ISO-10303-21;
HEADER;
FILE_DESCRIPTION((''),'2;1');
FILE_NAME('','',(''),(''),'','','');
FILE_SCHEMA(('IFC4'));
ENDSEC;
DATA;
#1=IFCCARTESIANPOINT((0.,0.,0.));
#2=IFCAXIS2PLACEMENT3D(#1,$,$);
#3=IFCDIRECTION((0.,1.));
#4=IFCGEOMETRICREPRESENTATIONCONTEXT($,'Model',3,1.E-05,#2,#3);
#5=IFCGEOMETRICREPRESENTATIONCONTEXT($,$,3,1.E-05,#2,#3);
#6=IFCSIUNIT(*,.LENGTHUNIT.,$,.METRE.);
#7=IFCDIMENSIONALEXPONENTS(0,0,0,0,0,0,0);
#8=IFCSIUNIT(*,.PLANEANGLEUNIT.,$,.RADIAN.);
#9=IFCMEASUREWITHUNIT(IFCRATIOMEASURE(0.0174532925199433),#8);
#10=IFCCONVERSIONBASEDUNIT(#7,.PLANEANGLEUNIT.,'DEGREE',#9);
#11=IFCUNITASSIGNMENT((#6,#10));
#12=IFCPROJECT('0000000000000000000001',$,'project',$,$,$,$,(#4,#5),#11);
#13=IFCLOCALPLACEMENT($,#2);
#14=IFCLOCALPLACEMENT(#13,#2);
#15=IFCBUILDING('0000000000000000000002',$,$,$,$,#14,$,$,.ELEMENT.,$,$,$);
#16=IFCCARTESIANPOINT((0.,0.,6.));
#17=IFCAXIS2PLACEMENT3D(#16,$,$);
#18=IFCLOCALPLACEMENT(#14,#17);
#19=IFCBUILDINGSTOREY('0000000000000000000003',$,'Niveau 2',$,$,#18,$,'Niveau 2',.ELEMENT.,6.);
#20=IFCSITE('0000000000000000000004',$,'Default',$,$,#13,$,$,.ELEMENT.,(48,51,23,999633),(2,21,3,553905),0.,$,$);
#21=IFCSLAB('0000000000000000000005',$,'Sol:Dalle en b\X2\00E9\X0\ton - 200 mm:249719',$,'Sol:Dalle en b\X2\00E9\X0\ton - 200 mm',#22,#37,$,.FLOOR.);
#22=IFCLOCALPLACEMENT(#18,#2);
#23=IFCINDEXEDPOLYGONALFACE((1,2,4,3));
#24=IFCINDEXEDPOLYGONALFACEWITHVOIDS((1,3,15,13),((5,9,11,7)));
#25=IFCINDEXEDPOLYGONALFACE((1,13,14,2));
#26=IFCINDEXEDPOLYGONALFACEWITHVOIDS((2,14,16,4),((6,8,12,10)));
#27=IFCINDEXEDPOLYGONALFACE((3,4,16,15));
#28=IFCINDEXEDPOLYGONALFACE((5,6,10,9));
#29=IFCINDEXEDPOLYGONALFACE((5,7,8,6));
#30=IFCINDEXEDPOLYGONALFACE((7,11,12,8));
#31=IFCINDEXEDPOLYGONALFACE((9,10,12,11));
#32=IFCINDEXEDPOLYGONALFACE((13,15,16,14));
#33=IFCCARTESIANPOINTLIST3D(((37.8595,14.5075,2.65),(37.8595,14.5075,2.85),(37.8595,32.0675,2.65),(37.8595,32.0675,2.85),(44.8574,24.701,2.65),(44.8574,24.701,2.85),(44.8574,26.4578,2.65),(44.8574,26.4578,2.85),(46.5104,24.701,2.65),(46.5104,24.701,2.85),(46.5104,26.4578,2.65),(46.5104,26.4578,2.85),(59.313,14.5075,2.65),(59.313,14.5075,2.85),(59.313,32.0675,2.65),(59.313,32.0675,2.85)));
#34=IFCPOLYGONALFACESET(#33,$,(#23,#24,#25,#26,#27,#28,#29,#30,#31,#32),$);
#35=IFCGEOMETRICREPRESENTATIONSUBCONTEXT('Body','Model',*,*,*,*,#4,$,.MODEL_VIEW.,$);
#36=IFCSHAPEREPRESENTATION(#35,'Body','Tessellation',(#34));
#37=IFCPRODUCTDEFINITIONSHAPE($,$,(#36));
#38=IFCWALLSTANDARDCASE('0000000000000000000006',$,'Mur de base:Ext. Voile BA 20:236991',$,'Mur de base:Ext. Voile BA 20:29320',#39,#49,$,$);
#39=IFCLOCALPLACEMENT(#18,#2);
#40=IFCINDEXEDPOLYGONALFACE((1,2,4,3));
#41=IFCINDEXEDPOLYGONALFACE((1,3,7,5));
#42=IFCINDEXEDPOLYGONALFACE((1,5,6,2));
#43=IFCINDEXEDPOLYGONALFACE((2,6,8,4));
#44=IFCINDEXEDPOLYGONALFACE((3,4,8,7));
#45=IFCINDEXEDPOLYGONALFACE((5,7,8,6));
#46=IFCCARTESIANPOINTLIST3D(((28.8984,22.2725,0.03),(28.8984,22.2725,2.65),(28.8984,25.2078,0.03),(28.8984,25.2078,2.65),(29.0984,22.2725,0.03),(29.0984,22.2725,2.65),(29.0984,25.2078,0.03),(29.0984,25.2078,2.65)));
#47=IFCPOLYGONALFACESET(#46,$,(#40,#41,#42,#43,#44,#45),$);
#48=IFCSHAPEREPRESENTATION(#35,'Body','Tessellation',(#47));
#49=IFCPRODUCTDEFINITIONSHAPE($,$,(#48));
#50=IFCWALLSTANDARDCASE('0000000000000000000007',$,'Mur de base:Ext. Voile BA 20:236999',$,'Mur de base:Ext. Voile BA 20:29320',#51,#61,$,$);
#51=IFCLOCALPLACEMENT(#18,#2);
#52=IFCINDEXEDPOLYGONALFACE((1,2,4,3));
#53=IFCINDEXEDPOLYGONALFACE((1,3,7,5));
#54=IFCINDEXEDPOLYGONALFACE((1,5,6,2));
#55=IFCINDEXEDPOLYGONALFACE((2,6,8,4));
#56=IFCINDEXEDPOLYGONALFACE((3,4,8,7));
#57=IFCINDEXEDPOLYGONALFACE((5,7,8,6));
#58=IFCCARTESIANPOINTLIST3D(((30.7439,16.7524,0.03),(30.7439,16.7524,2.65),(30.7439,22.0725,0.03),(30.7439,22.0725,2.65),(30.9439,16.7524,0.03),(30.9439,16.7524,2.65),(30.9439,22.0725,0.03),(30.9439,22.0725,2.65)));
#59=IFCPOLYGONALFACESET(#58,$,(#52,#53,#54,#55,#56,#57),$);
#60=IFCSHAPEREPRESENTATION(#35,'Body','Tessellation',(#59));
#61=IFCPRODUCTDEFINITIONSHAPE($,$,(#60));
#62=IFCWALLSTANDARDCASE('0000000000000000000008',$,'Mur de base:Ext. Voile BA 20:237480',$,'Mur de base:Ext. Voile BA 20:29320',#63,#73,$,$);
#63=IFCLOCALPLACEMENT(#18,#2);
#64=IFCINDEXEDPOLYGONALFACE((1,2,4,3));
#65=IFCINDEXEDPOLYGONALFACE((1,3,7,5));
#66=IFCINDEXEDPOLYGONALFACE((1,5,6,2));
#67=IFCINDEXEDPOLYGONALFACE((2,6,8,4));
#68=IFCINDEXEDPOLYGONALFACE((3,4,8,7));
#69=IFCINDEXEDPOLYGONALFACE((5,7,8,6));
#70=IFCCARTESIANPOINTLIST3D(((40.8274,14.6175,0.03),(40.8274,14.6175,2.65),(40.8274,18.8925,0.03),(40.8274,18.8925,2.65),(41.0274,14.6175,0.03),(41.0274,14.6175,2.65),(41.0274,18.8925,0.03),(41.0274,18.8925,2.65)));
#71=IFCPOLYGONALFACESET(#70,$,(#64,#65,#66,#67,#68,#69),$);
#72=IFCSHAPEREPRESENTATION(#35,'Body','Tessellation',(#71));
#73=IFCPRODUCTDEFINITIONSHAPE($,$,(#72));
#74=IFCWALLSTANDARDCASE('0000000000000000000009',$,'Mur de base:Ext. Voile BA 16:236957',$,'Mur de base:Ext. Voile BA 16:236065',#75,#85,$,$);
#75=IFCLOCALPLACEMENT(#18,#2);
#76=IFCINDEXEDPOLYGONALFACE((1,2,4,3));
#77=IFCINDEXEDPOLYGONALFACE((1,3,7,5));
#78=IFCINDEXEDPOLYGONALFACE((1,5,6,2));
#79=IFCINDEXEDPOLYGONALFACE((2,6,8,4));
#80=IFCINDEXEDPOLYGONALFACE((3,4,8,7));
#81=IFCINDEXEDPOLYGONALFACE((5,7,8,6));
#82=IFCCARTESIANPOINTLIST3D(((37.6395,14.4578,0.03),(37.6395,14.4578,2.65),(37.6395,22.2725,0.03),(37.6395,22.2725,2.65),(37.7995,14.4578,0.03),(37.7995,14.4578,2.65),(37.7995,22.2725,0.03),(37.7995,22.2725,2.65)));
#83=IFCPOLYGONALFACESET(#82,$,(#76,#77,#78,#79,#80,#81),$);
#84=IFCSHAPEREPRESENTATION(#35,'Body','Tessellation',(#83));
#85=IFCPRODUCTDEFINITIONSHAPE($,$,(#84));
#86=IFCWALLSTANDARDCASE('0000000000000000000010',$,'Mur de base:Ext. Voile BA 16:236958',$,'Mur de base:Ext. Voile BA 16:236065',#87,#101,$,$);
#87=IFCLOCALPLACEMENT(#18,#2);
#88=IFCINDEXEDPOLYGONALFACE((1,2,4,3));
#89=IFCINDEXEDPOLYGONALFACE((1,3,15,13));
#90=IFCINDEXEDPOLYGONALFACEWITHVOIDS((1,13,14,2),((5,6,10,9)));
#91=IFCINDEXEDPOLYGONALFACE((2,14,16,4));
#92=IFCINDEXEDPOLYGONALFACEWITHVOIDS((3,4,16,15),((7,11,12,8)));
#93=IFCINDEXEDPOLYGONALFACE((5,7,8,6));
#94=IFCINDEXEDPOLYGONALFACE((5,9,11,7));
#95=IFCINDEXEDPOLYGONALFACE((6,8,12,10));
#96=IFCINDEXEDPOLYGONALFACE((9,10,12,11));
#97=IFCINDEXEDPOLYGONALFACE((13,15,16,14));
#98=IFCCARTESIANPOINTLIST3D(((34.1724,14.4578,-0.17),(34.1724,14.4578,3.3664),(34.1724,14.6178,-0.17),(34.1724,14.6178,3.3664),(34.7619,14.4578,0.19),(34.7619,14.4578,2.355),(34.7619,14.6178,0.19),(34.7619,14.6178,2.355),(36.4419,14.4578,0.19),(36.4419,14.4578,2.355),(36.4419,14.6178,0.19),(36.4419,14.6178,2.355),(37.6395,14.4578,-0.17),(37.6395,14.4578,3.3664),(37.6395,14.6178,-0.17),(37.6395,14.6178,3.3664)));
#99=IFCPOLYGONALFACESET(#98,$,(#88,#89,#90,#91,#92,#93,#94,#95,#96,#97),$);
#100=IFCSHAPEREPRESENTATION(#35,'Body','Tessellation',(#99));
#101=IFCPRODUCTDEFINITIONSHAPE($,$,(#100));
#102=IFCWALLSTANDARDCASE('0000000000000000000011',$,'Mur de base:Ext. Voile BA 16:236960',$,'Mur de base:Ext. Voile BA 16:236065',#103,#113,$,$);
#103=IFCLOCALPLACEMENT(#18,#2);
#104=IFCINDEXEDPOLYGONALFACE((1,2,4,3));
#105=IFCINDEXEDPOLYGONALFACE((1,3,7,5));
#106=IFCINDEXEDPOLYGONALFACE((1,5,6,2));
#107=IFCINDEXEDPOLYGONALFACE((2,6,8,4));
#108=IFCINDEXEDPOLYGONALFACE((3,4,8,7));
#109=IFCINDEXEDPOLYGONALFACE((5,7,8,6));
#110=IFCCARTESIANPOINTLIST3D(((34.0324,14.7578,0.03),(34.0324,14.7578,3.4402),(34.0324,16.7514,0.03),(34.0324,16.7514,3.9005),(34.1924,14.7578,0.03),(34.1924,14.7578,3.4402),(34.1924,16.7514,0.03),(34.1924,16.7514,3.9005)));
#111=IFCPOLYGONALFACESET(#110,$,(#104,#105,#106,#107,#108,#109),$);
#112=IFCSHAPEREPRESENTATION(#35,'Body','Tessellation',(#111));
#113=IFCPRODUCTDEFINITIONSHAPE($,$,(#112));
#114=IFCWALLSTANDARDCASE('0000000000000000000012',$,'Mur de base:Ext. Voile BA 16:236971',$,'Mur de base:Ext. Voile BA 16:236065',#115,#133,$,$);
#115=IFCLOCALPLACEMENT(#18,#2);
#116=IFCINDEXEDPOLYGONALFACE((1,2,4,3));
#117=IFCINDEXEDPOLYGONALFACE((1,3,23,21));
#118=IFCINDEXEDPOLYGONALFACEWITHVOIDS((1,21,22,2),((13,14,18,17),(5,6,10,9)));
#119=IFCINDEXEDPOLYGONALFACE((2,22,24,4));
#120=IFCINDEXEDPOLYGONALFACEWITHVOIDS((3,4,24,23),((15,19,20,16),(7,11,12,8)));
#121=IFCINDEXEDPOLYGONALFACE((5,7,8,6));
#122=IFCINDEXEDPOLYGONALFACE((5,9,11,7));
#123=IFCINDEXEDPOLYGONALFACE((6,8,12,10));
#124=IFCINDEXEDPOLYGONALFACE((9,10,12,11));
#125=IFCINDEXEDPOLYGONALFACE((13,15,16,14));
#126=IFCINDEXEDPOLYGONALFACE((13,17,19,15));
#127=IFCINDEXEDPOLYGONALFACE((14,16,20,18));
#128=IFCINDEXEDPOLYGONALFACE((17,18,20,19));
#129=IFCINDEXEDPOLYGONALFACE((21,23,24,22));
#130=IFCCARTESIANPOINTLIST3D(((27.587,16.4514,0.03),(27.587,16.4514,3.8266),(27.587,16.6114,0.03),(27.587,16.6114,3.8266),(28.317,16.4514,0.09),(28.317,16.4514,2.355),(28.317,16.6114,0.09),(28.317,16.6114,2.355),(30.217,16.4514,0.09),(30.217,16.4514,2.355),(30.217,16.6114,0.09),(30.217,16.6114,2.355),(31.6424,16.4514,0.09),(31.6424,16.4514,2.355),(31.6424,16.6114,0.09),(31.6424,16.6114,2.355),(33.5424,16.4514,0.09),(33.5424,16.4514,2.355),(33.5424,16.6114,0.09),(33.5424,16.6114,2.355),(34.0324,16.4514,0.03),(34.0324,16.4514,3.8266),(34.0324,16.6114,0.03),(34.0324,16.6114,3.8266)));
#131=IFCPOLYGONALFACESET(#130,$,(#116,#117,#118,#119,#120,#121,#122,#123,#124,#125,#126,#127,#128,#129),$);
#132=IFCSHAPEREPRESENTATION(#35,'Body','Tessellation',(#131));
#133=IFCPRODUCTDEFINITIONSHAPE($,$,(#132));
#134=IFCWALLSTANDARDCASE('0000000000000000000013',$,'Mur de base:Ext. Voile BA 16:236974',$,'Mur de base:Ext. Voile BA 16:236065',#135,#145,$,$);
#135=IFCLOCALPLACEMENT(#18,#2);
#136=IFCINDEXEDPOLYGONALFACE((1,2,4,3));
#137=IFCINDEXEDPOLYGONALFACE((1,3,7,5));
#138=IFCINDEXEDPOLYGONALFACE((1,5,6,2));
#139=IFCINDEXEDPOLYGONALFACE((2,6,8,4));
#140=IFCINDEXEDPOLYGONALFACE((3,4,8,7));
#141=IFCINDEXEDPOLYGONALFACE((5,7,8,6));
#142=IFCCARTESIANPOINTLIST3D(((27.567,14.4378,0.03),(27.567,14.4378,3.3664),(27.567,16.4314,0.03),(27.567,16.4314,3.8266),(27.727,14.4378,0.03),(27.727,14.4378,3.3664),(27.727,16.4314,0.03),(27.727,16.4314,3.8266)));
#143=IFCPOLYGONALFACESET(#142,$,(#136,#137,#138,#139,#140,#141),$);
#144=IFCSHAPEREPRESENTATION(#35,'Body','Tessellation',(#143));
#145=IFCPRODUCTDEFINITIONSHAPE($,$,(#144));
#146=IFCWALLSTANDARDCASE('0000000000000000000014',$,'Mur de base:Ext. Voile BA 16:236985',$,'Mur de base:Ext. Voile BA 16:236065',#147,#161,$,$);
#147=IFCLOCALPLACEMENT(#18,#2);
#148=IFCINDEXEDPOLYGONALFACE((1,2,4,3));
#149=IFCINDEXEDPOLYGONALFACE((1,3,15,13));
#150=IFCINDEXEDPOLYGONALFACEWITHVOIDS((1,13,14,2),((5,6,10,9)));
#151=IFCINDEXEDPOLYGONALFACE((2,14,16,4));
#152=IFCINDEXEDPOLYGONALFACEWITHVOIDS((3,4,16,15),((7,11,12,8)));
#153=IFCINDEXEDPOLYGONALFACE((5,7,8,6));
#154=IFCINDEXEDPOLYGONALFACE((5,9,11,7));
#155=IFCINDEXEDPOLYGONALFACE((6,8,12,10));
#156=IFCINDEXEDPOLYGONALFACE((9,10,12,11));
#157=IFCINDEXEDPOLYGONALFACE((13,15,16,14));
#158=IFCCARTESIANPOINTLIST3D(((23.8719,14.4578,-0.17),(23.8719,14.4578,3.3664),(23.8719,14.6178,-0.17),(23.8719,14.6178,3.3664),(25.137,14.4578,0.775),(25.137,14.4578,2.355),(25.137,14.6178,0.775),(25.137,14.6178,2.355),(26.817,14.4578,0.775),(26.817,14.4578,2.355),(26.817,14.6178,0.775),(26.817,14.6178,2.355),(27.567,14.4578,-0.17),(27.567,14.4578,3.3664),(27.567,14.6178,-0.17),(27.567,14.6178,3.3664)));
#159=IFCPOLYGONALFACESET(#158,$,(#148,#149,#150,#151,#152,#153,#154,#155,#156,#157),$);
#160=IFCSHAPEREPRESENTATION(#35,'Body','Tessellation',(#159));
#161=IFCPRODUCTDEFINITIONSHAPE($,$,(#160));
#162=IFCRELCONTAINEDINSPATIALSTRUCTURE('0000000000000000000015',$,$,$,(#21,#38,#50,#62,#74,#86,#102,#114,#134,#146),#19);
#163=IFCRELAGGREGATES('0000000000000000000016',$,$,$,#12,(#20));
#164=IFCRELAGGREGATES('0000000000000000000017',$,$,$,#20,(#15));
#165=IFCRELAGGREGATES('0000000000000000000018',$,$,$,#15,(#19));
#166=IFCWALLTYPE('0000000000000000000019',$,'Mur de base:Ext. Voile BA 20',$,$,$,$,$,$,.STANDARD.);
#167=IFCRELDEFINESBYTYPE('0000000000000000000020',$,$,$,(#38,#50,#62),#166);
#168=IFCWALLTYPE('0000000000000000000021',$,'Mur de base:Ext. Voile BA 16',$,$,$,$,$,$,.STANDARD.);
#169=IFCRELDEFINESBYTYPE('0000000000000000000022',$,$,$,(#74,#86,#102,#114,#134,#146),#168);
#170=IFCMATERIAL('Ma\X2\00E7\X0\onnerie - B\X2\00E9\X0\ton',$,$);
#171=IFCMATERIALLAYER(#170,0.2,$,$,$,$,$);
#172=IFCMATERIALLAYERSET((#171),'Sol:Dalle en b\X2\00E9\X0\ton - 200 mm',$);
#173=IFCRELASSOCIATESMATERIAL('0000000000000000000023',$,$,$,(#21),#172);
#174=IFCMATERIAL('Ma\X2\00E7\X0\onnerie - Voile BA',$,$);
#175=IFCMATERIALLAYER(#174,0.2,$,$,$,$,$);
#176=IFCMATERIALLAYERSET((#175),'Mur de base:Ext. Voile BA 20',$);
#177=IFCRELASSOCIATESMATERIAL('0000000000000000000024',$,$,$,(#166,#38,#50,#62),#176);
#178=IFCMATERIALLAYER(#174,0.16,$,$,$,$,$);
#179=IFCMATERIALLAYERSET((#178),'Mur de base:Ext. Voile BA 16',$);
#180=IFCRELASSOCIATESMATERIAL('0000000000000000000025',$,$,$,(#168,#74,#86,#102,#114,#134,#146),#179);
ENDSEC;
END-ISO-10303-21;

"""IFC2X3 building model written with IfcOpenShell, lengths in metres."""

from ifc_helpers import new_model, entity, si_unit, converted_unit, direction, frame, frame_2d, origin, origin_2d_with_axis, place, context, subcontext, project, spatial, rectangle, extrude, clip, halfspace, material, layer, layer_set, layer_usage, type_object, element, save


model = new_model("IFC2X3")

# Units and contexts
model_context = context("Model", 3, precision=1e-05, world=origin(), true_north=direction((0.0, 1.0)))
context_of_model = context(None, 3, precision=1e-05, world=origin(), true_north=direction((0.0, 1.0)))
body_context = subcontext(model_context, "Body", "Model", "MODEL_VIEW")
ifc_project = project(units=[si_unit("LENGTHUNIT", "METRE"), converted_unit("PLANEANGLEUNIT", "DEGREE", entity("IfcRatioMeasure", 0.0174532925199433), si_unit("PLANEANGLEUNIT", "RADIAN"), dimensions=[0, 0, 0, 0, 0, 0, 0])], contexts=[model_context, context_of_model])

# Site, building, storey
site_placement = place(None, origin())
site = spatial("IfcSite", under=ifc_project, at=site_placement, Name="Default", CompositionType="ELEMENT", RefLatitude=(48, 51, 23, 999633), RefLongitude=(2, 21, 3, 553905), RefElevation=0.0)
building_placement = place(site_placement, origin())
building = spatial("IfcBuilding", under=site, at=building_placement, CompositionType="ELEMENT")
storey_placement = place(building_placement, frame((0.0, 0.0, 6.0)))
storey = spatial("IfcBuildingStorey", under=building, at=storey_placement, Name="Niveau 2", LongName="Niveau 2", CompositionType="ELEMENT", Elevation=6.0)

# Slab, opening
ifc_material_1 = material(Name="Maçonnerie - Béton")
ifc_layer_1 = layer(ifc_material_1, 0.2)
ifc_layer_set_1 = layer_set([ifc_layer_1], Name="Sol:Dalle en béton - 200 mm")
ifc_layer_usage_1 = layer_usage(ifc_layer_set_1, "AXIS3", "POSITIVE", 0.0)
slab_1_placement = place(storey_placement, frame((37.8595, 14.5075, 2.65)))
slab_1 = element("IfcSlab", 1, at=slab_1_placement, inside=storey, material=ifc_layer_usage_1, Name="Sol:Dalle en béton - 200 mm:249719", ObjectType="Sol:Dalle en béton - 200 mm", PredefinedType="FLOOR", context=body_context, shape_type="SweptSolid", body=[
    extrude(rectangle(XDim=21.4535, YDim=17.56, at=origin_2d_with_axis()), frame((10.7267, 8.78, 0.2), z_axis=(0.0, 0.0, -1.0), x_axis=(-1.0, 0.0, 0.0)), (0.0, 0.0, 1.0), 0.2),
])
opening_1_placement = place(slab_1_placement, frame((7.8244, 11.0719, 0.2)))
element("IfcOpeningElement", 2, at=opening_1_placement, cuts=slab_1, ObjectType="Opening", context=body_context, shape_type="SweptSolid", body=[
    extrude(rectangle(XDim=1.653, YDim=1.7568, at=origin_2d_with_axis()), frame((0.0, 0.0, 0.0), z_axis=(0.0, 0.0, -1.0), x_axis=(-1.0, 0.0, 0.0)), (0.0, 0.0, 1.0), 0.2),
])

# Walls
ifc_material_2 = material(Name="Maçonnerie - Voile BA")
ifc_layer_2 = layer(ifc_material_2, 0.2)
ifc_layer_set_2 = layer_set([ifc_layer_2], Name="Mur de base:Ext. Voile BA 20")
ifc_layer_usage_2 = layer_usage(ifc_layer_set_2, "AXIS2", "NEGATIVE", 0.1)
wall_type_1 = type_object("IfcWallType", Name="Mur de base:Ext. Voile BA 20", PredefinedType="STANDARD", material=ifc_layer_set_2)
wall_1_placement = place(storey_placement, frame((28.9984, 22.2725, 0.03), z_axis=(0.0, 0.0, 1.0), x_axis=(0.0, 1.0, 0.0)))
element("IfcWallStandardCase", 3, at=wall_1_placement, inside=storey, type_object=wall_type_1, material=ifc_layer_usage_2, Name="Mur de base:Ext. Voile BA 20:236991", ObjectType="Mur de base:Ext. Voile BA 20:29320", context=body_context, shape_type="SweptSolid", body=[
    extrude(rectangle(XDim=2.9353, YDim=0.2, at=frame_2d((1.4677, 0.0), x_axis=(-1.0, 0.0))), origin(), (0.0, 0.0, 1.0), 2.62),
])
ifc_layer_usage_3 = layer_usage(ifc_layer_set_2, "AXIS2", "NEGATIVE", 0.1)
wall_2_placement = place(storey_placement, frame((30.8439, 22.0725, 0.03), z_axis=(0.0, 0.0, 1.0), x_axis=(0.0, -1.0, 0.0)))
element("IfcWallStandardCase", 4, at=wall_2_placement, inside=storey, type_object=wall_type_1, material=ifc_layer_usage_3, Name="Mur de base:Ext. Voile BA 20:236999", ObjectType="Mur de base:Ext. Voile BA 20:29320", context=body_context, shape_type="SweptSolid", body=[
    extrude(rectangle(XDim=5.3201, YDim=0.2, at=frame_2d((2.66, 0.0), x_axis=(-1.0, 0.0))), origin(), (0.0, 0.0, 1.0), 2.62),
])
ifc_layer_usage_4 = layer_usage(ifc_layer_set_2, "AXIS2", "NEGATIVE", 0.1)
wall_3_placement = place(storey_placement, frame((40.9274, 14.6175, 0.03), z_axis=(0.0, 0.0, 1.0), x_axis=(0.0, 1.0, 0.0)))
element("IfcWallStandardCase", 5, at=wall_3_placement, inside=storey, type_object=wall_type_1, material=ifc_layer_usage_4, Name="Mur de base:Ext. Voile BA 20:237480", ObjectType="Mur de base:Ext. Voile BA 20:29320", context=body_context, shape_type="SweptSolid", body=[
    extrude(rectangle(XDim=4.275, YDim=0.2, at=frame_2d((2.1375, 0.0), x_axis=(-1.0, 0.0))), origin(), (0.0, 0.0, 1.0), 2.62),
])
ifc_layer_3 = layer(ifc_material_2, 0.16)
ifc_layer_set_3 = layer_set([ifc_layer_3], Name="Mur de base:Ext. Voile BA 16")
ifc_layer_usage_5 = layer_usage(ifc_layer_set_3, "AXIS2", "NEGATIVE", 0.08)
wall_type_2 = type_object("IfcWallType", Name="Mur de base:Ext. Voile BA 16", PredefinedType="STANDARD", material=ifc_layer_set_3)
wall_4_placement = place(storey_placement, frame((37.7195, 22.2725, 0.03), z_axis=(0.0, 0.0, 1.0), x_axis=(0.0, -1.0, 0.0)))
element("IfcWallStandardCase", 6, at=wall_4_placement, inside=storey, type_object=wall_type_2, material=ifc_layer_usage_5, Name="Mur de base:Ext. Voile BA 16:236957", ObjectType="Mur de base:Ext. Voile BA 16:236065", context=body_context, shape_type="SweptSolid", body=[
    extrude(rectangle(XDim=7.8147, YDim=0.16, at=frame_2d((3.9073, 0.0), x_axis=(-1.0, 0.0))), origin(), (0.0, 0.0, 1.0), 2.62),
])

# Wall, opening
ifc_layer_usage_6 = layer_usage(ifc_layer_set_3, "AXIS2", "NEGATIVE", 0.08)
wall_5_placement = place(storey_placement, frame((37.6395, 14.5378, -0.17), z_axis=(0.0, 0.0, 1.0), x_axis=(-1.0, 0.0, 0.0)))
wall_5 = element("IfcWallStandardCase", 7, at=wall_5_placement, inside=storey, type_object=wall_type_2, material=ifc_layer_usage_6, Name="Mur de base:Ext. Voile BA 16:236958", ObjectType="Mur de base:Ext. Voile BA 16:236065", context=body_context, shape_type="SweptSolid", body=[
    extrude(rectangle(XDim=3.4671, YDim=0.16, at=frame_2d((1.7335, 0.0), x_axis=(-1.0, 0.0))), origin(), (0.0, 0.0, 1.0), 3.5364),
])
opening_2_placement = place(wall_5_placement, origin())
element("IfcOpeningElement", 8, at=opening_2_placement, cuts=wall_5, ObjectType="Opening", context=body_context, shape_type="SweptSolid", body=[
    extrude(rectangle(XDim=2.165, YDim=1.68, at=origin_2d_with_axis()), frame((2.0376, -0.08, 1.4425), z_axis=(0.0, 1.0, 0.0), x_axis=(0.0, 0.0, -1.0)), (0.0, 0.0, 1.0), 0.16),
])

# Wall
ifc_layer_usage_7 = layer_usage(ifc_layer_set_3, "AXIS2", "NEGATIVE", 0.08)
wall_6_placement = place(storey_placement, frame((34.1124, 14.7578, 0.03), z_axis=(0.0, 0.0, 1.0), x_axis=(0.0, 1.0, 0.0)))
element("IfcWallStandardCase", 9, at=wall_6_placement, inside=storey, type_object=wall_type_2, material=ifc_layer_usage_7, Name="Mur de base:Ext. Voile BA 16:236960", ObjectType="Mur de base:Ext. Voile BA 16:236065", context=body_context, shape_type="Clipping", body=[
    clip(extrude(rectangle(XDim=1.9936, YDim=0.16, at=frame_2d((0.9968, 0.0), x_axis=(-1.0, 0.0))), origin(), (0.0, 0.0, 1.0), 3.8705), halfspace(frame((0.0, -0.08, 3.4102), z_axis=(-0.224951, 0.0, 0.97437), x_axis=(0.0, 1.0, 0.0)), False)),
])

# Wall, openings
ifc_layer_usage_8 = layer_usage(ifc_layer_set_3, "AXIS2", "NEGATIVE", 0.08)
wall_7_placement = place(storey_placement, frame((34.0324, 16.5314, 0.03), z_axis=(0.0, 0.0, 1.0), x_axis=(-1.0, 0.0, 0.0)))
wall_7 = element("IfcWallStandardCase", 10, at=wall_7_placement, inside=storey, type_object=wall_type_2, material=ifc_layer_usage_8, Name="Mur de base:Ext. Voile BA 16:236971", ObjectType="Mur de base:Ext. Voile BA 16:236065", context=body_context, shape_type="SweptSolid", body=[
    extrude(rectangle(XDim=6.4454, YDim=0.16, at=frame_2d((3.2227, 0.0), x_axis=(-1.0, 0.0))), origin(), (0.0, 0.0, 1.0), 3.7966),
])
opening_3_placement = place(wall_7_placement, origin())
element("IfcOpeningElement", 11, at=opening_3_placement, cuts=wall_7, ObjectType="Opening", context=body_context, shape_type="SweptSolid", body=[
    extrude(rectangle(XDim=2.265, YDim=1.9, at=origin_2d_with_axis()), frame((1.44, -0.08, 1.1925), z_axis=(0.0, 1.0, 0.0), x_axis=(0.0, 0.0, -1.0)), (0.0, 0.0, 1.0), 0.16),
])
opening_4_placement = place(wall_7_placement, origin())
element("IfcOpeningElement", 12, at=opening_4_placement, cuts=wall_7, ObjectType="Opening", context=body_context, shape_type="SweptSolid", body=[
    extrude(rectangle(XDim=2.265, YDim=1.9, at=origin_2d_with_axis()), frame((4.7654, -0.08, 1.1925), z_axis=(0.0, 1.0, 0.0), x_axis=(0.0, 0.0, -1.0)), (0.0, 0.0, 1.0), 0.16),
])

# Wall
ifc_layer_usage_9 = layer_usage(ifc_layer_set_3, "AXIS2", "NEGATIVE", 0.08)
wall_8_placement = place(storey_placement, frame((27.647, 16.4314, 0.03), z_axis=(0.0, 0.0, 1.0), x_axis=(0.0, -1.0, 0.0)))
element("IfcWallStandardCase", 13, at=wall_8_placement, inside=storey, type_object=wall_type_2, material=ifc_layer_usage_9, Name="Mur de base:Ext. Voile BA 16:236974", ObjectType="Mur de base:Ext. Voile BA 16:236065", context=body_context, shape_type="Clipping", body=[
    clip(extrude(rectangle(XDim=1.9936, YDim=0.16, at=frame_2d((0.9968, 0.0), x_axis=(-1.0, 0.0))), origin(), (0.0, 0.0, 1.0), 3.7966), halfspace(frame((0.0, -0.08, 3.7966), z_axis=(0.224951, 0.0, 0.97437), x_axis=(0.0, 1.0, 0.0)), False)),
])

# Wall, opening
ifc_layer_usage_10 = layer_usage(ifc_layer_set_3, "AXIS2", "NEGATIVE", 0.08)
wall_9_placement = place(storey_placement, frame((27.567, 14.5378, -0.17), z_axis=(0.0, 0.0, 1.0), x_axis=(-1.0, 0.0, 0.0)))
wall_9 = element("IfcWallStandardCase", 14, at=wall_9_placement, inside=storey, type_object=wall_type_2, material=ifc_layer_usage_10, Name="Mur de base:Ext. Voile BA 16:236985", ObjectType="Mur de base:Ext. Voile BA 16:236065", context=body_context, shape_type="SweptSolid", body=[
    extrude(rectangle(XDim=3.695, YDim=0.16, at=frame_2d((1.8475, 0.0), x_axis=(-1.0, 0.0))), origin(), (0.0, 0.0, 1.0), 3.5364),
])
opening_5_placement = place(wall_9_placement, origin())
element("IfcOpeningElement", 15, at=opening_5_placement, cuts=wall_9, ObjectType="Opening", context=body_context, shape_type="SweptSolid", body=[
    extrude(rectangle(XDim=1.58, YDim=1.68, at=origin_2d_with_axis()), frame((1.59, -0.08, 1.735), z_axis=(0.0, 1.0, 0.0), x_axis=(0.0, 0.0, -1.0)), (0.0, 0.0, 1.0), 0.16),
])

save(model, "model.ifc")
